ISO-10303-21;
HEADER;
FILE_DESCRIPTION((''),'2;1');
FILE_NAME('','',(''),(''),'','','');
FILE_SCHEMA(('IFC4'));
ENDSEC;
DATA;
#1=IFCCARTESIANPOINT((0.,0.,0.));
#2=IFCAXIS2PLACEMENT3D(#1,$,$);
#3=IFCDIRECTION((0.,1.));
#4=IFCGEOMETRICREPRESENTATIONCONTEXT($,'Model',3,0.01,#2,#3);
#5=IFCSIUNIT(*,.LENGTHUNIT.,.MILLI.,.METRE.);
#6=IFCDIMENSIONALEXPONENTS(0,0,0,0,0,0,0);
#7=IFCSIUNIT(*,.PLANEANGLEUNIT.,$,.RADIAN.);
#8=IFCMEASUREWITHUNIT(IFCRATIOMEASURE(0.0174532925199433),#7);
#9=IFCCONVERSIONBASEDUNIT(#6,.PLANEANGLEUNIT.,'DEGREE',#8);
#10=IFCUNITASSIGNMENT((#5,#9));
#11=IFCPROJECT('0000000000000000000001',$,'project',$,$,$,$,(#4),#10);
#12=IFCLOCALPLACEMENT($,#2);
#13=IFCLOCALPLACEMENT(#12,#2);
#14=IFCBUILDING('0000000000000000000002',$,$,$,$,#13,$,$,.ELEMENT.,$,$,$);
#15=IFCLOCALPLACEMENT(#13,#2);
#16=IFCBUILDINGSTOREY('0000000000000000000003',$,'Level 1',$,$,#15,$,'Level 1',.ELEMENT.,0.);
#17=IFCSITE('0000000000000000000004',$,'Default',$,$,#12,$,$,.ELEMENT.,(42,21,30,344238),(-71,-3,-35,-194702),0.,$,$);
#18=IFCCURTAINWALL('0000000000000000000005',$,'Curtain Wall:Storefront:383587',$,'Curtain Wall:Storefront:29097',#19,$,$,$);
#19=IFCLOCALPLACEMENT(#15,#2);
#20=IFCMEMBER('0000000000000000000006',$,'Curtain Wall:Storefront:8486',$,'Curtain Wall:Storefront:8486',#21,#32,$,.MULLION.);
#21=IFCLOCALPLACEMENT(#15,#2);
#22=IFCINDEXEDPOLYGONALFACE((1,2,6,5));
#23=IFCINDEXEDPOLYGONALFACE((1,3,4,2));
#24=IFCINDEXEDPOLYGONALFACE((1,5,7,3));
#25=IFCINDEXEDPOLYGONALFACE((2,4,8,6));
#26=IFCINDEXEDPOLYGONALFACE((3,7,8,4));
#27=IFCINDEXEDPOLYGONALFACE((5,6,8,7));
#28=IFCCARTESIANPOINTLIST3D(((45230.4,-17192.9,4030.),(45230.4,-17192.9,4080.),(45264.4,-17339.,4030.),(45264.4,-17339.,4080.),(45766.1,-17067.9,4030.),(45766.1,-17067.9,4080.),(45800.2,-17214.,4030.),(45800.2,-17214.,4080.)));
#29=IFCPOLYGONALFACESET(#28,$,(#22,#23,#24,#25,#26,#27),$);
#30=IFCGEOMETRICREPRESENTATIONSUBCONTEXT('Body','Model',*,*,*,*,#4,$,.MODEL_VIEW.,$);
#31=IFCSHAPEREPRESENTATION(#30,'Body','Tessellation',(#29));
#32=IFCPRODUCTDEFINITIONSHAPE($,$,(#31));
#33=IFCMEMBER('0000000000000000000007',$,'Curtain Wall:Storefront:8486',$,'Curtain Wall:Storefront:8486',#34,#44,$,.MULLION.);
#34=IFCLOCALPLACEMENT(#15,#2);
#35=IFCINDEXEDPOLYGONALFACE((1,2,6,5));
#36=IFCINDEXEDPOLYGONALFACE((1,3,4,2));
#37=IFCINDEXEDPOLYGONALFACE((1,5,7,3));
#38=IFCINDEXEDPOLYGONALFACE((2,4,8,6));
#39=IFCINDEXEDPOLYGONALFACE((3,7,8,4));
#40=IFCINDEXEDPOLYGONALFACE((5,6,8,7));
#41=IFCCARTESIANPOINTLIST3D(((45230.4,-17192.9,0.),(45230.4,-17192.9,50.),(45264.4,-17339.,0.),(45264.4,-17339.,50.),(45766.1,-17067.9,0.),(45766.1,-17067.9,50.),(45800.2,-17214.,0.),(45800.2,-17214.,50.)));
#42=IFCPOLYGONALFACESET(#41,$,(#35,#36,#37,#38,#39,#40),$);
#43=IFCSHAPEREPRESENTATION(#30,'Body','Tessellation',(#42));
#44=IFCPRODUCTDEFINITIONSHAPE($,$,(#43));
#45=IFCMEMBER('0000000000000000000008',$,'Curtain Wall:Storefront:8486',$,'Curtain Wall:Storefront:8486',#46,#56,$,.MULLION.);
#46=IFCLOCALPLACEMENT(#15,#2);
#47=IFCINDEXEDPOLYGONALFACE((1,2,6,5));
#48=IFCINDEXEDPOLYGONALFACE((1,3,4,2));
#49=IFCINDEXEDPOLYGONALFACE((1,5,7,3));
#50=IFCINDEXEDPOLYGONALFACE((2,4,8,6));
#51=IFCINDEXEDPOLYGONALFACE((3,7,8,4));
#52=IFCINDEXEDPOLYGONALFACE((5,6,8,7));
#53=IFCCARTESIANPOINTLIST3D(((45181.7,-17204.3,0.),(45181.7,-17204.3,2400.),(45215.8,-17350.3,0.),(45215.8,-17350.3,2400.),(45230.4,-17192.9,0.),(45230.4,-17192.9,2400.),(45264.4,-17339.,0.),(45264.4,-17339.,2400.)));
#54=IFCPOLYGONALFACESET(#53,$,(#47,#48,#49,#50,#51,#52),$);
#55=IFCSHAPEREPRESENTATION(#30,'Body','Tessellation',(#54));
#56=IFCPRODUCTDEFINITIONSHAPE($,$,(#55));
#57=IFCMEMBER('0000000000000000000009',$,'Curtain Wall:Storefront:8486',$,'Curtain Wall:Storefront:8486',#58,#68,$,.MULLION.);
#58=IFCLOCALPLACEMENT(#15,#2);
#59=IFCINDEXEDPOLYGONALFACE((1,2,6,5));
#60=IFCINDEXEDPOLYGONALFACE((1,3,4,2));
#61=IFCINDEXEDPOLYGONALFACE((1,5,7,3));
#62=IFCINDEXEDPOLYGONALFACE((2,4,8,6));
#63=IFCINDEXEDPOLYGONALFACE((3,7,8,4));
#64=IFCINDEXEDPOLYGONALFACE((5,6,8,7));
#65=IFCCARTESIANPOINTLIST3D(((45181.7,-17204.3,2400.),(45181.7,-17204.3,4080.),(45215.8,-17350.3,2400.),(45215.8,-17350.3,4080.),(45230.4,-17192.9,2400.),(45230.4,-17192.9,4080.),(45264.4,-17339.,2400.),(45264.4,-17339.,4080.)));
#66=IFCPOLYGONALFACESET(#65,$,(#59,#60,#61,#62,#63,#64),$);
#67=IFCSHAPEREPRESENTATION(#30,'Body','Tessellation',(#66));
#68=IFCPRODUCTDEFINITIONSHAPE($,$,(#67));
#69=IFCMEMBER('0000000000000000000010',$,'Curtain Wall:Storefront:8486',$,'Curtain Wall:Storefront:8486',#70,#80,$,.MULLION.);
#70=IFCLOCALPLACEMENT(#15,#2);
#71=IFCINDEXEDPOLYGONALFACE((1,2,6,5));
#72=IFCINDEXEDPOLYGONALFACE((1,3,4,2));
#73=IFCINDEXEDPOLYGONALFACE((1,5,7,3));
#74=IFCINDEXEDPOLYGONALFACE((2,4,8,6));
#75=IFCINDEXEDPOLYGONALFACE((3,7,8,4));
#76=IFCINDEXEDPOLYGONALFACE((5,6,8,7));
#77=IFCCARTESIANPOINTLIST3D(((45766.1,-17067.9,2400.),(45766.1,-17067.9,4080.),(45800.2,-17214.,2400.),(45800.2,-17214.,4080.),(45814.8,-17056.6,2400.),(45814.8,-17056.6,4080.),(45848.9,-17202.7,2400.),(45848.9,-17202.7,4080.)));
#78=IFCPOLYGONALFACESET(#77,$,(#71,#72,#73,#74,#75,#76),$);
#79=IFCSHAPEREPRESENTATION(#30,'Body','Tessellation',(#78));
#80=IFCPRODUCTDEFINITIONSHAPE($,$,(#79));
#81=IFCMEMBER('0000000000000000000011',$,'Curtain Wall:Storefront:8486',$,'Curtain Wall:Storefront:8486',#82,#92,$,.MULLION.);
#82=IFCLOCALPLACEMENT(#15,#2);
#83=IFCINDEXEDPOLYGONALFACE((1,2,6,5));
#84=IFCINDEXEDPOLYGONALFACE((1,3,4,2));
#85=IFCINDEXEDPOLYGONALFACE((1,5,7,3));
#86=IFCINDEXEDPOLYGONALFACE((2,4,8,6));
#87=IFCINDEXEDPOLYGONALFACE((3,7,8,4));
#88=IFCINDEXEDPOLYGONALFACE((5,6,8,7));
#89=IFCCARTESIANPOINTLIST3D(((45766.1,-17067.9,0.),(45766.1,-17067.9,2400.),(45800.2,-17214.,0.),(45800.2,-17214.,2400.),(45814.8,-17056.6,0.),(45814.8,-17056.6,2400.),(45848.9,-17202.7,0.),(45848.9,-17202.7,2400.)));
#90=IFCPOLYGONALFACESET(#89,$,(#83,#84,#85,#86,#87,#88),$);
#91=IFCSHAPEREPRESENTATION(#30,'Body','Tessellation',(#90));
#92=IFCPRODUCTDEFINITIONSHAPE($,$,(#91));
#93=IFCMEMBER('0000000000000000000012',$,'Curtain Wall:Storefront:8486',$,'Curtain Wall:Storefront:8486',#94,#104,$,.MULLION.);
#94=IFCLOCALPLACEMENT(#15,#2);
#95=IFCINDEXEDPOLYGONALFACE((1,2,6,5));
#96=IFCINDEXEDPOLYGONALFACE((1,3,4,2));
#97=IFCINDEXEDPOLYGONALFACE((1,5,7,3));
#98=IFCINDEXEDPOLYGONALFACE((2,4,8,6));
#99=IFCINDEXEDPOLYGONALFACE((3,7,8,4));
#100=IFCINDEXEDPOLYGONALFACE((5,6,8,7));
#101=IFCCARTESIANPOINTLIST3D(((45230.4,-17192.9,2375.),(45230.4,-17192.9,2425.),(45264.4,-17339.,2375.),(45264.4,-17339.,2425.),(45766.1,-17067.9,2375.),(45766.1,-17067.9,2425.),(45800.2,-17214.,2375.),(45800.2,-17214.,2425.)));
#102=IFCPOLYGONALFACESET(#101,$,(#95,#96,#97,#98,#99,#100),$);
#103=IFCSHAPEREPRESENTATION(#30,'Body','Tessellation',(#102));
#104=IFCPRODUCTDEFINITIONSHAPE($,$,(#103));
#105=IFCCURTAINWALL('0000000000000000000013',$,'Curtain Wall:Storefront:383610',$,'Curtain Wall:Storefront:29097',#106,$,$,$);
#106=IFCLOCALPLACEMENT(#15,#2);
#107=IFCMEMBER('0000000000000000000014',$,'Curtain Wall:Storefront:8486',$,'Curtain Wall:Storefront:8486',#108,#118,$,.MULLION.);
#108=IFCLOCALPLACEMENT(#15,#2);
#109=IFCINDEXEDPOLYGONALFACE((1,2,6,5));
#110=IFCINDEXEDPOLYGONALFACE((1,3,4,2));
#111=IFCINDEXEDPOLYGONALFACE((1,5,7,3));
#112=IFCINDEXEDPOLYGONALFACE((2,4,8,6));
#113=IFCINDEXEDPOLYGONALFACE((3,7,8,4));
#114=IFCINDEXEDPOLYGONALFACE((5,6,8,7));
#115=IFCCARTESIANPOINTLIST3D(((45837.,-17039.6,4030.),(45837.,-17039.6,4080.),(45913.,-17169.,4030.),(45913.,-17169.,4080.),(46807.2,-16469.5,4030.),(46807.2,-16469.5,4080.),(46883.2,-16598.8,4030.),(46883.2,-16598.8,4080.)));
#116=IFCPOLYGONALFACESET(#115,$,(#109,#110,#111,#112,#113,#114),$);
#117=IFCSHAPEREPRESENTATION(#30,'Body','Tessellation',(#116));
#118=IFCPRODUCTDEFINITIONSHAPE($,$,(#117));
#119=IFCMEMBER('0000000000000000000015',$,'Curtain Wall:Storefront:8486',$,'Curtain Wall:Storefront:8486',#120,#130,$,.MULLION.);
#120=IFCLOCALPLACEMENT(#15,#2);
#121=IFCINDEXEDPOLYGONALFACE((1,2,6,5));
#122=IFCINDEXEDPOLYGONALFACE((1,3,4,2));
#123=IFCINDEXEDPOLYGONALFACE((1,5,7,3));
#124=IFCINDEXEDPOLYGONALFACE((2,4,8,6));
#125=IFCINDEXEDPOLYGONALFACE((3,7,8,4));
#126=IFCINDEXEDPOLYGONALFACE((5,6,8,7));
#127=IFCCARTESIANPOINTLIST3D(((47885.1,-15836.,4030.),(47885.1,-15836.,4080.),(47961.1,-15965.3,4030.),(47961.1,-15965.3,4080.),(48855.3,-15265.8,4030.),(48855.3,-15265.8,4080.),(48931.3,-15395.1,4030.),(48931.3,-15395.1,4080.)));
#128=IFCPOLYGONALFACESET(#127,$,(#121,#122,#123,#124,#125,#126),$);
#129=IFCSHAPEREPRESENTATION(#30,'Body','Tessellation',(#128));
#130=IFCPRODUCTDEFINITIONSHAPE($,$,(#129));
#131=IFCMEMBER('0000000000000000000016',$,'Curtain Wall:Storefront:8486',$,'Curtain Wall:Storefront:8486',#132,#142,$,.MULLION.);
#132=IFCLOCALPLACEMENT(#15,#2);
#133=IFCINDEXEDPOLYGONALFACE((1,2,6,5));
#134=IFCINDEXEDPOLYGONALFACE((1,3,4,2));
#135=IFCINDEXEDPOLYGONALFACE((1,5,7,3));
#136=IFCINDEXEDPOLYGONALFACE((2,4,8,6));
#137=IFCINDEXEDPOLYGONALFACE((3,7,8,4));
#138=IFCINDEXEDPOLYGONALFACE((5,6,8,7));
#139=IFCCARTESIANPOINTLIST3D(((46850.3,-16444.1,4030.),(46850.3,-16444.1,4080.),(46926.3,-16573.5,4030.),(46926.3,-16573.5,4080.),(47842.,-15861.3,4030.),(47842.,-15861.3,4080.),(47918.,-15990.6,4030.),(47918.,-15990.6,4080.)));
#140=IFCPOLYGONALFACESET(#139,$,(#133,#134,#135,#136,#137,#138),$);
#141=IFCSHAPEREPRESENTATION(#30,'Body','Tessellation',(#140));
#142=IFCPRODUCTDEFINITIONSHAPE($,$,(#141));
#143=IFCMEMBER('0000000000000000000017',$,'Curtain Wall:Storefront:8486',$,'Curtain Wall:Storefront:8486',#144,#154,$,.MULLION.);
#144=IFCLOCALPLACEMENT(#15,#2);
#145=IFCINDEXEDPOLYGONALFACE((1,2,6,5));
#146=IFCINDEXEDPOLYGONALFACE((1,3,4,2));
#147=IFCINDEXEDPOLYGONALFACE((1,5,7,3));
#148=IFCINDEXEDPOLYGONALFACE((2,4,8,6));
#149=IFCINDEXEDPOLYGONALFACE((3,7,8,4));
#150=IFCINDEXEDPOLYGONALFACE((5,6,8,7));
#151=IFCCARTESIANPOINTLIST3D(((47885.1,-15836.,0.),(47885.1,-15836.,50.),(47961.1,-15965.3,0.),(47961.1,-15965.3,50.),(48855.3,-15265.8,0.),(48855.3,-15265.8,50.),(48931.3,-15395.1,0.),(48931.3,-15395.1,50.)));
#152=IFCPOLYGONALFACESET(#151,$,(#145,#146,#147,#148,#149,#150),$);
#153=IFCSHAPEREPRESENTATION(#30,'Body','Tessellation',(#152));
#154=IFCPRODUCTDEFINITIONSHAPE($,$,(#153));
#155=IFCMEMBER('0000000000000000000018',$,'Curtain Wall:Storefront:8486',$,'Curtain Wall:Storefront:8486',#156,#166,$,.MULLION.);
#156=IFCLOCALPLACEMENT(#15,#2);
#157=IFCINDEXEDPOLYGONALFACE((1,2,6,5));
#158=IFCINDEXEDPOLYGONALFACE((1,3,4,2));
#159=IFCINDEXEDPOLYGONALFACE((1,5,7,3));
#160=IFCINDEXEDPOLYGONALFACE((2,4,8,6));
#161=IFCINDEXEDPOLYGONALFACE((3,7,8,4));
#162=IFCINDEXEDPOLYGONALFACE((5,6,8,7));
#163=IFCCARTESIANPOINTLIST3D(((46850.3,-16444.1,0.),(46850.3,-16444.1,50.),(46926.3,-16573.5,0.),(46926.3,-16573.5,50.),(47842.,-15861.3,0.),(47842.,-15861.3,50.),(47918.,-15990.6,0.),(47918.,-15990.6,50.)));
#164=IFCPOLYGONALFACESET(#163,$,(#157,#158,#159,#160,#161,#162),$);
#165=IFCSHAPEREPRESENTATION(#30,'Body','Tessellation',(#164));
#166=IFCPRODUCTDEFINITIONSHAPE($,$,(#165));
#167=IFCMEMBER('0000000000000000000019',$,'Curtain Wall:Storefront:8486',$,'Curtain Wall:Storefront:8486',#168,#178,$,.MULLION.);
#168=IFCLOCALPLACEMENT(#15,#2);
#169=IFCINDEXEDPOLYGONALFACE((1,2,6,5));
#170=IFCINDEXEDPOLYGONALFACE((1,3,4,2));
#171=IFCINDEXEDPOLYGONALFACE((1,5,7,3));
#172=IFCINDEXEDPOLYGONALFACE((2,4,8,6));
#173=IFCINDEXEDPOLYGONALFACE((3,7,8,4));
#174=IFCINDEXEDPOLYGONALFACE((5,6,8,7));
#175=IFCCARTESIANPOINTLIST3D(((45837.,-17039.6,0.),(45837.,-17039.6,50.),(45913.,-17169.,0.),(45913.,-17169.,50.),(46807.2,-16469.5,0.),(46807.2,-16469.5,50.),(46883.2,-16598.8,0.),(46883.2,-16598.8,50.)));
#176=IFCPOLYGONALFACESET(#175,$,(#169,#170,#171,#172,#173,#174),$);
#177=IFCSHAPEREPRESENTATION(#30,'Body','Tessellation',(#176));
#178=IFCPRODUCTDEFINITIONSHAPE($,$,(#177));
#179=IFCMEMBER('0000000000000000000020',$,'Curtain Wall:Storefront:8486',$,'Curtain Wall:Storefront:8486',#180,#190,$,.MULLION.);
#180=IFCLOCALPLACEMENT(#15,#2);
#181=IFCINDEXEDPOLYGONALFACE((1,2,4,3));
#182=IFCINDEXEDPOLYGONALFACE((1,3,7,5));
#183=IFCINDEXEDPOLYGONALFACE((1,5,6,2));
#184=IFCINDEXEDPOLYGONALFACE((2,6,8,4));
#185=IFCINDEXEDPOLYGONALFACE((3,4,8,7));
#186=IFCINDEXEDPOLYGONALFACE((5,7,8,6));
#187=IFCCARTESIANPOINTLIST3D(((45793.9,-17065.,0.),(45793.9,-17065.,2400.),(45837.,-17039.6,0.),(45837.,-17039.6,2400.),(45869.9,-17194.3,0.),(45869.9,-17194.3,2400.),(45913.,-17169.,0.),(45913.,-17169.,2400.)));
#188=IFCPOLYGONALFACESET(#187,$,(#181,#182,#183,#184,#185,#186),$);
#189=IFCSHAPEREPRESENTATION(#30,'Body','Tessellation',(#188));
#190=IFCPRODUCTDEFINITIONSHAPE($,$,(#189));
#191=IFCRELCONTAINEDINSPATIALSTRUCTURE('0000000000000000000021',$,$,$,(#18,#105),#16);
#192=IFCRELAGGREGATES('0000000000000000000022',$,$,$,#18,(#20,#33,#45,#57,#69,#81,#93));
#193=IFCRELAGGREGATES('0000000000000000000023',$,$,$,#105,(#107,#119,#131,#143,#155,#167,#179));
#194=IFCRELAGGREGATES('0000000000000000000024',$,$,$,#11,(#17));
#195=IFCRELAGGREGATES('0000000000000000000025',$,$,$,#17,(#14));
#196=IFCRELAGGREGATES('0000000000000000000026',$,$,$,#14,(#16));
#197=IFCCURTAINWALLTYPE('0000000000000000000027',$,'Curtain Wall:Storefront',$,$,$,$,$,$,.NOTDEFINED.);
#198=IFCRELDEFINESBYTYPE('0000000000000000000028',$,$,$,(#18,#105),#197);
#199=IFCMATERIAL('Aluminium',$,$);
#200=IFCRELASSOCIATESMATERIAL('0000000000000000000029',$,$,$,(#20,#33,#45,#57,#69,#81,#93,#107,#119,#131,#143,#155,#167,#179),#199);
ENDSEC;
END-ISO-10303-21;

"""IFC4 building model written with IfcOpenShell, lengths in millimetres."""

from ifc_helpers import new_model, entity, si_unit, converted_unit, direction, frame, frame_2d, origin, origin_2d_with_axis, place, context, subcontext, project, spatial, rectangle, extrude, material, type_object, element, aggregate, save


model = new_model("IFC4")

# Units and contexts
model_context = context("Model", 3, precision=0.01, world=origin(), true_north=direction((0.0, 1.0)))
body_context = subcontext(model_context, "Body", "Model", "MODEL_VIEW")
ifc_project = project(units=[si_unit("LENGTHUNIT", "METRE", prefix="MILLI"), converted_unit("PLANEANGLEUNIT", "DEGREE", entity("IfcRatioMeasure", 0.0174532925199433), si_unit("PLANEANGLEUNIT", "RADIAN"), dimensions=[0, 0, 0, 0, 0, 0, 0])], contexts=[model_context])

# Site, building, storey
site_placement = place(None, origin())
site = spatial("IfcSite", under=ifc_project, at=site_placement, Name="Default", CompositionType="ELEMENT", RefLatitude=(42, 21, 30, 344238), RefLongitude=(-71, -3, -35, -194702), RefElevation=0.0)
building_placement = place(site_placement, origin())
building = spatial("IfcBuilding", under=site, at=building_placement, CompositionType="ELEMENT")
storey_placement = place(building_placement, origin())
storey = spatial("IfcBuildingStorey", under=building, at=storey_placement, Name="Level 1", LongName="Level 1", CompositionType="ELEMENT", Elevation=0.0)

# Curtain walls, members
curtain_wall_type = type_object("IfcCurtainWallType", Name="Curtain Wall:Storefront", PredefinedType="NOTDEFINED")
ifc_material = material(Name="Aluminium")
curtain_wall_1_placement = place(storey_placement, origin())
curtain_wall_1 = element("IfcCurtainWall", 1, at=curtain_wall_1_placement, inside=storey, type_object=curtain_wall_type, Name="Curtain Wall:Storefront:383587", ObjectType="Curtain Wall:Storefront:29097")
member_1_placement = place(curtain_wall_1_placement, origin())
member_1 = element("IfcMember", 2, at=member_1_placement, material=ifc_material, Name="Curtain Wall:Storefront:8486", ObjectType="Curtain Wall:Storefront:8486", PredefinedType="MULLION", context=body_context, shape_type="SweptSolid", body=[
    extrude(rectangle(XDim=50.0, YDim=150.0, at=frame_2d((0.0, 0.0), x_axis=(1.0, 0.0))), frame((45247.4, -17265.9, 4055.0), z_axis=(0.973861, 0.227145, 0.0), x_axis=(0.0, 0.0, -1.0)), (0.0, 0.0, 1.0), 550.1),
])
member_2_placement = place(curtain_wall_1_placement, origin())
member_2 = element("IfcMember", 3, at=member_2_placement, material=ifc_material, Name="Curtain Wall:Storefront:8486", ObjectType="Curtain Wall:Storefront:8486", PredefinedType="MULLION", context=body_context, shape_type="SweptSolid", body=[
    extrude(rectangle(XDim=50.0, YDim=150.0, at=frame_2d((0.0, 0.0), x_axis=(1.0, 0.0))), frame((45783.2, -17141.0, 25.0), z_axis=(-0.973861, -0.227145, 0.0), x_axis=(0.0, 0.0, -1.0)), (0.0, 0.0, 1.0), 550.1),
])
member_3_placement = place(curtain_wall_1_placement, origin())
member_3 = element("IfcMember", 4, at=member_3_placement, material=ifc_material, Name="Curtain Wall:Storefront:8486", ObjectType="Curtain Wall:Storefront:8486", PredefinedType="MULLION", context=body_context, shape_type="SweptSolid", body=[
    extrude(rectangle(XDim=150.0, YDim=50.0, at=origin_2d_with_axis()), frame((45223.1, -17271.6, 0.0), z_axis=(0.0, 0.0, 1.0), x_axis=(-0.227145, 0.973861, 0.0)), (0.0, 0.0, 1.0), 2400.0),
])
member_4_placement = place(curtain_wall_1_placement, origin())
member_4 = element("IfcMember", 5, at=member_4_placement, material=ifc_material, Name="Curtain Wall:Storefront:8486", ObjectType="Curtain Wall:Storefront:8486", PredefinedType="MULLION", context=body_context, shape_type="SweptSolid", body=[
    extrude(rectangle(XDim=150.0, YDim=50.0, at=origin_2d_with_axis()), frame((45223.1, -17271.6, 2400.0), z_axis=(0.0, 0.0, 1.0), x_axis=(-0.227145, 0.973861, 0.0)), (0.0, 0.0, 1.0), 1680.0),
])
member_5_placement = place(curtain_wall_1_placement, origin())
member_5 = element("IfcMember", 6, at=member_5_placement, material=ifc_material, Name="Curtain Wall:Storefront:8486", ObjectType="Curtain Wall:Storefront:8486", PredefinedType="MULLION", context=body_context, shape_type="SweptSolid", body=[
    extrude(rectangle(XDim=50.0, YDim=150.0, at=origin_2d_with_axis()), frame((45807.5, -17135.3, 4080.0), z_axis=(0.0, 0.0, -1.0), x_axis=(0.973861, 0.227145, 0.0)), (0.0, 0.0, 1.0), 1680.0),
])
member_6_placement = place(curtain_wall_1_placement, origin())
member_6 = element("IfcMember", 7, at=member_6_placement, material=ifc_material, Name="Curtain Wall:Storefront:8486", ObjectType="Curtain Wall:Storefront:8486", PredefinedType="MULLION", context=body_context, shape_type="SweptSolid", body=[
    extrude(rectangle(XDim=50.0, YDim=150.0, at=origin_2d_with_axis()), frame((45807.5, -17135.3, 2400.0), z_axis=(0.0, 0.0, -1.0), x_axis=(0.973861, 0.227145, 0.0)), (0.0, 0.0, 1.0), 2400.0),
])
member_7_placement = place(curtain_wall_1_placement, origin())
member_7 = element("IfcMember", 8, at=member_7_placement, material=ifc_material, Name="Curtain Wall:Storefront:8486", ObjectType="Curtain Wall:Storefront:8486", PredefinedType="MULLION", context=body_context, shape_type="SweptSolid", body=[
    extrude(rectangle(XDim=50.0, YDim=150.0, at=frame_2d((0.0, 0.0), x_axis=(1.0, 0.0))), frame((45247.4, -17265.9, 2400.0), z_axis=(0.973861, 0.227145, 0.0), x_axis=(0.0, 0.0, -1.0)), (0.0, 0.0, 1.0), 550.1),
])
aggregate(curtain_wall_1, [member_1, member_2, member_3, member_4, member_5, member_6, member_7])
curtain_wall_2_placement = place(storey_placement, origin())
curtain_wall_2 = element("IfcCurtainWall", 9, at=curtain_wall_2_placement, inside=storey, type_object=curtain_wall_type, Name="Curtain Wall:Storefront:383610", ObjectType="Curtain Wall:Storefront:29097")
member_8_placement = place(curtain_wall_2_placement, origin())
member_8 = element("IfcMember", 10, at=member_8_placement, material=ifc_material, Name="Curtain Wall:Storefront:8486", ObjectType="Curtain Wall:Storefront:8486", PredefinedType="MULLION", context=body_context, shape_type="SweptSolid", body=[
    extrude(rectangle(XDim=50.0, YDim=150.0, at=frame_2d((0.0, 0.0), x_axis=(1.0, 0.0))), frame((45875.0, -17104.3, 4055.0), z_axis=(0.862143, 0.506665, 0.0), x_axis=(0.0, 0.0, -1.0)), (0.0, 0.0, 1.0), 1125.3),
])
member_9_placement = place(curtain_wall_2_placement, origin())
member_9 = element("IfcMember", 11, at=member_9_placement, material=ifc_material, Name="Curtain Wall:Storefront:8486", ObjectType="Curtain Wall:Storefront:8486", PredefinedType="MULLION", context=body_context, shape_type="SweptSolid", body=[
    extrude(rectangle(XDim=50.0, YDim=150.0, at=frame_2d((0.0, 0.0), x_axis=(1.0, 0.0))), frame((47923.1, -15900.6, 4055.0), z_axis=(0.862143, 0.506665, 0.0), x_axis=(0.0, 0.0, -1.0)), (0.0, 0.0, 1.0), 1125.3),
])
member_10_placement = place(curtain_wall_2_placement, origin())
member_10 = element("IfcMember", 12, at=member_10_placement, material=ifc_material, Name="Curtain Wall:Storefront:8486", ObjectType="Curtain Wall:Storefront:8486", PredefinedType="MULLION", context=body_context, shape_type="SweptSolid", body=[
    extrude(rectangle(XDim=50.0, YDim=150.0, at=frame_2d((0.0, 0.0), x_axis=(1.0, 0.0))), frame((46888.3, -16508.8, 4055.0), z_axis=(0.862143, 0.506665, 0.0), x_axis=(0.0, 0.0, -1.0)), (0.0, 0.0, 1.0), 1150.3),
])
member_11_placement = place(curtain_wall_2_placement, origin())
member_11 = element("IfcMember", 13, at=member_11_placement, material=ifc_material, Name="Curtain Wall:Storefront:8486", ObjectType="Curtain Wall:Storefront:8486", PredefinedType="MULLION", context=body_context, shape_type="SweptSolid", body=[
    extrude(rectangle(XDim=50.0, YDim=150.0, at=origin_2d_with_axis()), frame((48893.3, -15330.5, 25.0), z_axis=(-0.862143, -0.506665, 0.0), x_axis=(0.0, 0.0, -1.0)), (0.0, 0.0, 1.0), 1125.3),
])
member_12_placement = place(curtain_wall_2_placement, origin())
member_12 = element("IfcMember", 14, at=member_12_placement, material=ifc_material, Name="Curtain Wall:Storefront:8486", ObjectType="Curtain Wall:Storefront:8486", PredefinedType="MULLION", context=body_context, shape_type="SweptSolid", body=[
    extrude(rectangle(XDim=50.0, YDim=150.0, at=frame_2d((0.0, 0.0), x_axis=(1.0, 0.0))), frame((47880.0, -15926.0, 25.0), z_axis=(-0.862143, -0.506665, 0.0), x_axis=(0.0, 0.0, -1.0)), (0.0, 0.0, 1.0), 1150.3),
])
member_13_placement = place(curtain_wall_2_placement, origin())
member_13 = element("IfcMember", 15, at=member_13_placement, material=ifc_material, Name="Curtain Wall:Storefront:8486", ObjectType="Curtain Wall:Storefront:8486", PredefinedType="MULLION", context=body_context, shape_type="SweptSolid", body=[
    extrude(rectangle(XDim=50.0, YDim=150.0, at=frame_2d((0.0, 0.0), x_axis=(1.0, 0.0))), frame((46845.2, -16534.1, 25.0), z_axis=(-0.862143, -0.506665, 0.0), x_axis=(0.0, 0.0, -1.0)), (0.0, 0.0, 1.0), 1125.3),
])
member_14_placement = place(curtain_wall_2_placement, origin())
member_14 = element("IfcMember", 16, at=member_14_placement, material=ifc_material, Name="Curtain Wall:Storefront:8486", ObjectType="Curtain Wall:Storefront:8486", PredefinedType="MULLION", context=body_context, shape_type="SweptSolid", body=[
    extrude(rectangle(XDim=50.0, YDim=150.0, at=origin_2d_with_axis()), frame((45853.4, -17117.0, 0.0), z_axis=(0.0, 0.0, 1.0), x_axis=(0.862143, 0.506665, 0.0)), (0.0, 0.0, 1.0), 2400.0),
])
aggregate(curtain_wall_2, [member_8, member_9, member_10, member_11, member_12, member_13, member_14])

save(model, "model.ifc")
